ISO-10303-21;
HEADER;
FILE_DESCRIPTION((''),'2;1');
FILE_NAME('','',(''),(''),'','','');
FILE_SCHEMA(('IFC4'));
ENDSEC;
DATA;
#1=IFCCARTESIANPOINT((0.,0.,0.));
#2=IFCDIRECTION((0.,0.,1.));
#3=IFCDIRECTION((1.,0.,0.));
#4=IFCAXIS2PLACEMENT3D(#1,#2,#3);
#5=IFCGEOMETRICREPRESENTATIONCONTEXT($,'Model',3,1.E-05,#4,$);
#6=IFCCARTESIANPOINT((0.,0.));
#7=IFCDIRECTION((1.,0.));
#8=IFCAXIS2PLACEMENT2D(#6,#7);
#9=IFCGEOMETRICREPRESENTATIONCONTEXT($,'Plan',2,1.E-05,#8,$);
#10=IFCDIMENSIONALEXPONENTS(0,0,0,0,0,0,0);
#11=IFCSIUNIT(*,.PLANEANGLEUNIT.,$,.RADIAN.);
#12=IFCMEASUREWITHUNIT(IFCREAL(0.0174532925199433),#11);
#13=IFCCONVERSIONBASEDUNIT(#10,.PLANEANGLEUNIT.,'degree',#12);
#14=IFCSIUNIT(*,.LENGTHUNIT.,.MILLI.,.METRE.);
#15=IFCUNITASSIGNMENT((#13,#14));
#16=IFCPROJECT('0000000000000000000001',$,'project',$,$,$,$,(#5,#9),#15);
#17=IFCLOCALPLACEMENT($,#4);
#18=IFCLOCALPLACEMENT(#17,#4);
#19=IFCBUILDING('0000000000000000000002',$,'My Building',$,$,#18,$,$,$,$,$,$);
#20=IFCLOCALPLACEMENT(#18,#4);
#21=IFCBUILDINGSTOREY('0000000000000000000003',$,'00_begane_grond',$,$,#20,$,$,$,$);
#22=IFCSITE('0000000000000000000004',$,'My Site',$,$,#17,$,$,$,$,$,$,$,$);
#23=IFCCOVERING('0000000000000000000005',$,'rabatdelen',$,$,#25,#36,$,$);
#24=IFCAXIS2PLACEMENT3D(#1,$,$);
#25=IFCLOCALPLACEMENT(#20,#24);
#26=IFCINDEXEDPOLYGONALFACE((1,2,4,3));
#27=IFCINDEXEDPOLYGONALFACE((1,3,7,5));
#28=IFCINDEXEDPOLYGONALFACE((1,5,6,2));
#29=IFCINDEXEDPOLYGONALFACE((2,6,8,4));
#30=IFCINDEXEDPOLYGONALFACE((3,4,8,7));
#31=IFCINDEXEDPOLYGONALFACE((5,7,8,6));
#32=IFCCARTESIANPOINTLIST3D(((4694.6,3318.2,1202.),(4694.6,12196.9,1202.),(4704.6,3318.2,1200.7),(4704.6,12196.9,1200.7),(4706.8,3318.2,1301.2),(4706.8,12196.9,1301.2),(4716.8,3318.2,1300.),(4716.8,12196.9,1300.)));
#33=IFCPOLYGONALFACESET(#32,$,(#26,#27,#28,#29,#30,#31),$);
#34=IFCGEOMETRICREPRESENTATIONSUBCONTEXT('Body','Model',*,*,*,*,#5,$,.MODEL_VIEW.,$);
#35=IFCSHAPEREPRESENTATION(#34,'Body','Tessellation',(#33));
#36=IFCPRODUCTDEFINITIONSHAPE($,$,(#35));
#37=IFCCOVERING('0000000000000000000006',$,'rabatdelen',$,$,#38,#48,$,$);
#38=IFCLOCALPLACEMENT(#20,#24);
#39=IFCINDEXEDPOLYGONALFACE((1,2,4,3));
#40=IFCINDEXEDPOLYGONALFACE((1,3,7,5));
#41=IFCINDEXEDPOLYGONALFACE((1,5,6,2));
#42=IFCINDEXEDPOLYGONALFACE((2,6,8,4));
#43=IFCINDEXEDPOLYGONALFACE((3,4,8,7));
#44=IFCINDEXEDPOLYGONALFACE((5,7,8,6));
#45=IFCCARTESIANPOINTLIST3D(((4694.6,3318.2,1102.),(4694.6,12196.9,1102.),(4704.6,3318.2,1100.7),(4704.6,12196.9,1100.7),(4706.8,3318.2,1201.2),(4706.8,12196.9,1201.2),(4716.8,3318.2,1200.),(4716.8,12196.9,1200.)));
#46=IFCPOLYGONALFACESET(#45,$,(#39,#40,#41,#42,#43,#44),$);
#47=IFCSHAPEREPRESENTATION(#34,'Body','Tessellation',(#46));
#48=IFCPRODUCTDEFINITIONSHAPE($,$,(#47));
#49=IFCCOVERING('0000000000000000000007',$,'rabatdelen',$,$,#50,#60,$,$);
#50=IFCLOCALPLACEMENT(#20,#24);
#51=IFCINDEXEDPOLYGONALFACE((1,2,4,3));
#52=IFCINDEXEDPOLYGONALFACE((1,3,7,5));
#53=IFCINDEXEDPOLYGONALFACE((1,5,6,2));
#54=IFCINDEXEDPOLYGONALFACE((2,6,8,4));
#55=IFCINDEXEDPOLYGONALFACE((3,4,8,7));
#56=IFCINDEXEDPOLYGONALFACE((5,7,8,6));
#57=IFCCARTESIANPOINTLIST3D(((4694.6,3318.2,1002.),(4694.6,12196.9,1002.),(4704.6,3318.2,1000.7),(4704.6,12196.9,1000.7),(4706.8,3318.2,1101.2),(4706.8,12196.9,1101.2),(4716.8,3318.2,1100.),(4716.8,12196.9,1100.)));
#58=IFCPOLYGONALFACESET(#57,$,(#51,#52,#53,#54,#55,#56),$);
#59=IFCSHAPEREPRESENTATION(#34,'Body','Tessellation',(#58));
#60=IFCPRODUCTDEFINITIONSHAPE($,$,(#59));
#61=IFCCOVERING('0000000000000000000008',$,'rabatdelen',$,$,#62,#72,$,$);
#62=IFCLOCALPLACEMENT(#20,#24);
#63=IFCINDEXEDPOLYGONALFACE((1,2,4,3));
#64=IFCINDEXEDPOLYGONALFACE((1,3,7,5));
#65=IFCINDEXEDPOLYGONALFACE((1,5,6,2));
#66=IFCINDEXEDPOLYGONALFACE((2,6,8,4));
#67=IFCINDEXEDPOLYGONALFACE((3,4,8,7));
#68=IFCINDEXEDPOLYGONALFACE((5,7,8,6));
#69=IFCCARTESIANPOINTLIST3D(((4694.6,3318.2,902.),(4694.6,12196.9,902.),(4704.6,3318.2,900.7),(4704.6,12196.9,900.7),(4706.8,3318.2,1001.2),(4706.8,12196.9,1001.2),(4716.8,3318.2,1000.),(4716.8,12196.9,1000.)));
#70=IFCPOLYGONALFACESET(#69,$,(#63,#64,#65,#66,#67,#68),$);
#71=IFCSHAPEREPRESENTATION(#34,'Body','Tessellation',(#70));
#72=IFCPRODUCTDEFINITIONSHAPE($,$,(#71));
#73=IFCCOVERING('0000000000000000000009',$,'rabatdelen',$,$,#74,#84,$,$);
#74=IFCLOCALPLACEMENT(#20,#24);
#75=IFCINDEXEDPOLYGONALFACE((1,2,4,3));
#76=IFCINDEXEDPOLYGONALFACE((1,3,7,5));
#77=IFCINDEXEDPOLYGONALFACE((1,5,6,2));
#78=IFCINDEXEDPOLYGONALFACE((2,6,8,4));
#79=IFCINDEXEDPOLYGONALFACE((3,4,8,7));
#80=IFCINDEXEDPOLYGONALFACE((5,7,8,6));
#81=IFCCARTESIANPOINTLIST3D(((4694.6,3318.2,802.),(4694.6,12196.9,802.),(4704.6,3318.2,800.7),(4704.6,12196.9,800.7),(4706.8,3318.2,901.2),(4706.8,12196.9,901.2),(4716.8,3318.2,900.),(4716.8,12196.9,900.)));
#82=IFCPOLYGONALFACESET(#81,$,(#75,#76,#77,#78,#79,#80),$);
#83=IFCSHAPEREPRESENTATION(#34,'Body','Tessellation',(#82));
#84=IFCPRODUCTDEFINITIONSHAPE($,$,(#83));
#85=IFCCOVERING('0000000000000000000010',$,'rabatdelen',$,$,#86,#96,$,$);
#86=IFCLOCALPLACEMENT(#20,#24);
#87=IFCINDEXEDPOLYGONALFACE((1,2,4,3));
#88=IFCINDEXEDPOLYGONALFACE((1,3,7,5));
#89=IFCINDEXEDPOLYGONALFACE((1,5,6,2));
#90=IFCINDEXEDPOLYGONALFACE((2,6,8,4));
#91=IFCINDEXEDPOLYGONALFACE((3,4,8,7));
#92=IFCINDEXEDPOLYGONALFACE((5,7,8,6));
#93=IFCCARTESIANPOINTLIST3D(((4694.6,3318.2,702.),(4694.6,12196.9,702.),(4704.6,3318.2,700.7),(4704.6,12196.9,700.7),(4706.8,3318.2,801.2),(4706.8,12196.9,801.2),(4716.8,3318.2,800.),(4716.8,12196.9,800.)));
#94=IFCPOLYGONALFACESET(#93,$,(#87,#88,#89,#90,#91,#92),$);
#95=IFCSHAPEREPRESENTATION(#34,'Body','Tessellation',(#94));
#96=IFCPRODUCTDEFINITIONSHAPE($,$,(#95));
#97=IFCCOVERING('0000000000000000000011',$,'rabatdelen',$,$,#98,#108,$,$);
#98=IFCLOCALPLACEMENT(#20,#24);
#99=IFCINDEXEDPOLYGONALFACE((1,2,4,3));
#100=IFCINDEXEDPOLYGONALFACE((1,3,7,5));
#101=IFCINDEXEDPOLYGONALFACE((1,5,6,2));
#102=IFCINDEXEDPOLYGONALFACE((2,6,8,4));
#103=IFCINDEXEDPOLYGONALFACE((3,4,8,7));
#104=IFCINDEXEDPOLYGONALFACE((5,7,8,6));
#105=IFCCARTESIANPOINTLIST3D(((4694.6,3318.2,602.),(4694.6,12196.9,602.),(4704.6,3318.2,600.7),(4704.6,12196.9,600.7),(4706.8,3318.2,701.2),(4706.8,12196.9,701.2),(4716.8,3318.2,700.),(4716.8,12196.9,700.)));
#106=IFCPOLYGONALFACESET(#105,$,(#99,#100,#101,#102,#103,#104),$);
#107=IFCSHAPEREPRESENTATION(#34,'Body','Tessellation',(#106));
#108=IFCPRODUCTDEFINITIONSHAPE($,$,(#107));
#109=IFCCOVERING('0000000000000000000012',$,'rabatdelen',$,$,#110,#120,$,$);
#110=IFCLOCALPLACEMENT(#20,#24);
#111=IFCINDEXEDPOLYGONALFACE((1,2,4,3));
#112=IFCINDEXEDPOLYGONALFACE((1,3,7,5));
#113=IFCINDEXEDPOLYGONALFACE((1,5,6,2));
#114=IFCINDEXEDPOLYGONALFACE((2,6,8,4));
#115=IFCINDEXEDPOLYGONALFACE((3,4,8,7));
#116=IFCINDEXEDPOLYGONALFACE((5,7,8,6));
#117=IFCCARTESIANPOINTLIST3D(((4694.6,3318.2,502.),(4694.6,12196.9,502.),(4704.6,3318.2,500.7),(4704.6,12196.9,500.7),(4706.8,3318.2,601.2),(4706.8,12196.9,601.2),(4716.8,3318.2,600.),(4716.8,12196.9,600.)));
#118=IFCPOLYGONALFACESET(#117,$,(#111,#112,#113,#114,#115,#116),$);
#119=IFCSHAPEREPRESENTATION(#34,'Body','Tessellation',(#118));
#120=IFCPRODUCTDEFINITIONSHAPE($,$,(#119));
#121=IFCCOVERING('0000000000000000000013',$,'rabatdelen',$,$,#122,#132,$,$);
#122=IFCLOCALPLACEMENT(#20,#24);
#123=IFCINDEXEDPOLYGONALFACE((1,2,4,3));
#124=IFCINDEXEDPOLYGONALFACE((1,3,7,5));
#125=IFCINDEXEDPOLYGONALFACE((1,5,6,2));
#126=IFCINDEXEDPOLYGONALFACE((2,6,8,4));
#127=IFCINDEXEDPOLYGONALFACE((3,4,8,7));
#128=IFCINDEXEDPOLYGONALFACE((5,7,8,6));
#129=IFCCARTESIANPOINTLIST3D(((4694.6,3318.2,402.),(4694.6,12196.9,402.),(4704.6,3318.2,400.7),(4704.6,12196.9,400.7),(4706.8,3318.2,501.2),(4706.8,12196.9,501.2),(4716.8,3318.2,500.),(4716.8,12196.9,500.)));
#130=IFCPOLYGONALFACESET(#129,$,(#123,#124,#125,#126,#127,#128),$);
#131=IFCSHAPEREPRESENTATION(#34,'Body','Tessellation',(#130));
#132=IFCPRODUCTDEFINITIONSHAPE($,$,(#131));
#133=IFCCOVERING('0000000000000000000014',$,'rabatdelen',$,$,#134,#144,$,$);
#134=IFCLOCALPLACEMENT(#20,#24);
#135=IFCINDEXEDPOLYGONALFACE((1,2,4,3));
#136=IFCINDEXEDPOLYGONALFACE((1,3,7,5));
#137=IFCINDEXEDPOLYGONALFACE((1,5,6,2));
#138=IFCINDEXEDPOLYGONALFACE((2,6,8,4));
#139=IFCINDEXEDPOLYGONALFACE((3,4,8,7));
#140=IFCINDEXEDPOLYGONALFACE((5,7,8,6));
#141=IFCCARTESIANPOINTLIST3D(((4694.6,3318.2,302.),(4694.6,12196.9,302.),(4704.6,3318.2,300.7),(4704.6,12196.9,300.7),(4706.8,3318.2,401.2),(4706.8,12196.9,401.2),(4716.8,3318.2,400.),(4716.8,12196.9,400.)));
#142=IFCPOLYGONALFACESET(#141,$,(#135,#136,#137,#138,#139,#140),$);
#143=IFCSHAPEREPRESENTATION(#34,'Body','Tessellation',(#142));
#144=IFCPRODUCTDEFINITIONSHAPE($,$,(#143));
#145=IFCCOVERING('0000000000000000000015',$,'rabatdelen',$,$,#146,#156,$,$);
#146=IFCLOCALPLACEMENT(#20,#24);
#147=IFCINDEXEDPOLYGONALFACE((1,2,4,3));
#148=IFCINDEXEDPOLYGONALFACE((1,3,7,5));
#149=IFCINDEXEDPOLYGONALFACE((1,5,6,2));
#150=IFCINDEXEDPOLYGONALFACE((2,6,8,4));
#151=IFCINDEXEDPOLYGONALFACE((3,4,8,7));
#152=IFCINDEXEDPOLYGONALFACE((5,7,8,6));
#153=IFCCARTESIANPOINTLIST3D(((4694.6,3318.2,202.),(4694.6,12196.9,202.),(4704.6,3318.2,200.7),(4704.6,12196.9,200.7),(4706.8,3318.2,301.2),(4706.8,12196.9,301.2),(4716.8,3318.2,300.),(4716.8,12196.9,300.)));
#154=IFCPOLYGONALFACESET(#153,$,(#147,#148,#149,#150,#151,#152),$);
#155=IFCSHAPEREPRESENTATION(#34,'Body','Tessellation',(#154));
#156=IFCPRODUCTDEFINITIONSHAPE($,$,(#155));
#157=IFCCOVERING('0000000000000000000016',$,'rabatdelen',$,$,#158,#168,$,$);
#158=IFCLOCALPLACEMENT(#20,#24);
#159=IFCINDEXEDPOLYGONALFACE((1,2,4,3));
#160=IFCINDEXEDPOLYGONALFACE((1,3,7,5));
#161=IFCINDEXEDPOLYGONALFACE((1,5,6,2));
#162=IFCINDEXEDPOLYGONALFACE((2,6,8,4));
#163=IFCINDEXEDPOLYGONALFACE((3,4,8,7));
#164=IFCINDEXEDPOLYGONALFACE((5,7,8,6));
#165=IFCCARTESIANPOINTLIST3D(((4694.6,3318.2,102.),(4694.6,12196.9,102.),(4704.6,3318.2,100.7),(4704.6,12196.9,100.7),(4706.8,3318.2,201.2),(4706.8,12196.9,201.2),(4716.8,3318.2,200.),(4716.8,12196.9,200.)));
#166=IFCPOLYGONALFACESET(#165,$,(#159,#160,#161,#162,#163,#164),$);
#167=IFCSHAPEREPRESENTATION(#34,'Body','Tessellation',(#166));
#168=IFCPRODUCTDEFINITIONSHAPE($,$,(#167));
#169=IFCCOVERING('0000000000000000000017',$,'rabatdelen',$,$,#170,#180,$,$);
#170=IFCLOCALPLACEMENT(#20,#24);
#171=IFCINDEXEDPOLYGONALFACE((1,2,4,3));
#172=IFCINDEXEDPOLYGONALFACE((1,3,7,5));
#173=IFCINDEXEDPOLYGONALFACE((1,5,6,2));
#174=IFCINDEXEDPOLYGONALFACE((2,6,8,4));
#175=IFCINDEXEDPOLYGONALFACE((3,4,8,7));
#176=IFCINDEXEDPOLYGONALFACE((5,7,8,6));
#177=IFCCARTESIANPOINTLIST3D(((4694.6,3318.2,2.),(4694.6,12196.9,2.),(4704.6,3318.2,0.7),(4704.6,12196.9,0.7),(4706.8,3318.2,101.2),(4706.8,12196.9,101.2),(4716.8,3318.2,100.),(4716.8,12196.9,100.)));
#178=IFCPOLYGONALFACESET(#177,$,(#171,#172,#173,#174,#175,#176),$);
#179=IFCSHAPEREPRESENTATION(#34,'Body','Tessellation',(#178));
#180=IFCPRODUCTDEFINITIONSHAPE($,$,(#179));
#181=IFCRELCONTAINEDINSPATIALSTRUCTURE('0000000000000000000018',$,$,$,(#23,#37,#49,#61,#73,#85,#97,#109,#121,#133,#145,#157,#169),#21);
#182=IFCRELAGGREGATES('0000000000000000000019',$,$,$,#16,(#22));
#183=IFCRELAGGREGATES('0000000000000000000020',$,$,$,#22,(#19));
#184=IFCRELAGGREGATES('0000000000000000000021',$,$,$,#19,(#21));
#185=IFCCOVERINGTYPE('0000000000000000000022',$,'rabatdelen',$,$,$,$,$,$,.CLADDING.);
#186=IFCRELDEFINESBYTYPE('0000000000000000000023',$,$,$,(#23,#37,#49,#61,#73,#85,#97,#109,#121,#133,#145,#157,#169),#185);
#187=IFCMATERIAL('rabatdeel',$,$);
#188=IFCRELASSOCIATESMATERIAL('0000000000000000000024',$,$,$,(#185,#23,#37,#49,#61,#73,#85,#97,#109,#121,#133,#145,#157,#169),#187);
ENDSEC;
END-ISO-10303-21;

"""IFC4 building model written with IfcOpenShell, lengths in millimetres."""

from ifc_helpers import new_model, entity, si_unit, converted_unit, frame, origin_with_axes, origin_2d_with_axis, place, context, subcontext, project, spatial, rectangle, extrude, material, material_profile, profile_set, profile_usage, type_object, element, save


model = new_model("IFC4")

# Units and contexts
model_context = context("Model", 3, precision=1e-05, world=origin_with_axes())
plan_context = context("Plan", 2, precision=1e-05, world=origin_2d_with_axis())
body_context = subcontext(model_context, "Body", "Model", "MODEL_VIEW")
ifc_project = project(units=[converted_unit("PLANEANGLEUNIT", "degree", entity("IfcReal", 0.0174532925199433), si_unit("PLANEANGLEUNIT", "RADIAN"), dimensions=[0, 0, 0, 0, 0, 0, 0]), si_unit("LENGTHUNIT", "METRE", prefix="MILLI")], contexts=[model_context, plan_context])

# Site, building, storey
site_placement = place(None, origin_with_axes())
site = spatial("IfcSite", under=ifc_project, at=site_placement, Name="My Site")
building_placement = place(site_placement, origin_with_axes())
building = spatial("IfcBuilding", under=site, at=building_placement, Name="My Building")
storey_placement = place(building_placement, origin_with_axes())
storey = spatial("IfcBuildingStorey", under=building, at=storey_placement, Name="00_begane_grond")

# Coverings
ifc_material_1 = material(Name="rabatdeel")
ifc_material_profile_1 = material_profile(ifc_material_1, rectangle(XDim=10.0, YDim=100.0))
ifc_profile_set_1 = profile_set([ifc_material_profile_1])
covering_type = type_object("IfcCoveringType", Name="rabatdelen", PredefinedType="CLADDING", material=ifc_profile_set_1)
ifc_profile_usage_1 = profile_usage(ifc_profile_set_1, cardinal=7)
covering_1_placement = place(storey_placement, frame((4716.8, 12196.9, 1300.0), z_axis=(0.0, -1.0, 0.0), x_axis=(0.992546, 0.0, -0.121869)))
element("IfcCovering", 1, at=covering_1_placement, inside=storey, type_object=covering_type, material=ifc_profile_usage_1, Name="rabatdelen", context=body_context, shape_type="SweptSolid", body=[
    extrude(rectangle(XDim=10.0, YDim=100.0), frame((-5.0, -50.0, 0.0), z_axis=(0.0, 0.0, 1.0), x_axis=(1.0, 0.0, 0.0)), (0.0, 0.0, 1.0), 8878.8),
])
ifc_profile_usage_2 = profile_usage(ifc_profile_set_1, cardinal=7)
covering_2_placement = place(storey_placement, frame((4716.8, 12196.9, 1200.0), z_axis=(0.0, -1.0, 0.0), x_axis=(0.992546, 0.0, -0.121869)))
element("IfcCovering", 2, at=covering_2_placement, inside=storey, type_object=covering_type, material=ifc_profile_usage_2, Name="rabatdelen", context=body_context, shape_type="SweptSolid", body=[
    extrude(rectangle(XDim=10.0, YDim=100.0), frame((-5.0, -50.0, 0.0), z_axis=(0.0, 0.0, 1.0), x_axis=(1.0, 0.0, 0.0)), (0.0, 0.0, 1.0), 8878.8),
])
ifc_profile_usage_3 = profile_usage(ifc_profile_set_1, cardinal=7)
covering_3_placement = place(storey_placement, frame((4716.8, 12196.9, 1100.0), z_axis=(0.0, -1.0, 0.0), x_axis=(0.992546, 0.0, -0.121869)))
element("IfcCovering", 3, at=covering_3_placement, inside=storey, type_object=covering_type, material=ifc_profile_usage_3, Name="rabatdelen", context=body_context, shape_type="SweptSolid", body=[
    extrude(rectangle(XDim=10.0, YDim=100.0), frame((-5.0, -50.0, 0.0), z_axis=(0.0, 0.0, 1.0), x_axis=(1.0, 0.0, 0.0)), (0.0, 0.0, 1.0), 8878.8),
])
ifc_profile_usage_4 = profile_usage(ifc_profile_set_1, cardinal=7)
covering_4_placement = place(storey_placement, frame((4716.8, 12196.9, 1000.0), z_axis=(0.0, -1.0, 0.0), x_axis=(0.992546, 0.0, -0.121869)))
element("IfcCovering", 4, at=covering_4_placement, inside=storey, type_object=covering_type, material=ifc_profile_usage_4, Name="rabatdelen", context=body_context, shape_type="SweptSolid", body=[
    extrude(rectangle(XDim=10.0, YDim=100.0), frame((-5.0, -50.0, 0.0), z_axis=(0.0, 0.0, 1.0), x_axis=(1.0, 0.0, 0.0)), (0.0, 0.0, 1.0), 8878.8),
])
ifc_profile_usage_5 = profile_usage(ifc_profile_set_1, cardinal=7)
covering_5_placement = place(storey_placement, frame((4716.8, 12196.9, 900.0), z_axis=(0.0, -1.0, 0.0), x_axis=(0.992546, 0.0, -0.121869)))
element("IfcCovering", 5, at=covering_5_placement, inside=storey, type_object=covering_type, material=ifc_profile_usage_5, Name="rabatdelen", context=body_context, shape_type="SweptSolid", body=[
    extrude(rectangle(XDim=10.0, YDim=100.0), frame((-5.0, -50.0, 0.0), z_axis=(0.0, 0.0, 1.0), x_axis=(1.0, 0.0, 0.0)), (0.0, 0.0, 1.0), 8878.8),
])
ifc_profile_usage_6 = profile_usage(ifc_profile_set_1, cardinal=7)
covering_6_placement = place(storey_placement, frame((4716.8, 12196.9, 800.0), z_axis=(0.0, -1.0, 0.0), x_axis=(0.992546, 0.0, -0.121869)))
element("IfcCovering", 6, at=covering_6_placement, inside=storey, type_object=covering_type, material=ifc_profile_usage_6, Name="rabatdelen", context=body_context, shape_type="SweptSolid", body=[
    extrude(rectangle(XDim=10.0, YDim=100.0), frame((-5.0, -50.0, 0.0), z_axis=(0.0, 0.0, 1.0), x_axis=(1.0, 0.0, 0.0)), (0.0, 0.0, 1.0), 8878.8),
])
ifc_profile_usage_7 = profile_usage(ifc_profile_set_1, cardinal=7)
covering_7_placement = place(storey_placement, frame((4716.8, 12196.9, 700.0), z_axis=(0.0, -1.0, 0.0), x_axis=(0.992546, 0.0, -0.121869)))
element("IfcCovering", 7, at=covering_7_placement, inside=storey, type_object=covering_type, material=ifc_profile_usage_7, Name="rabatdelen", context=body_context, shape_type="SweptSolid", body=[
    extrude(rectangle(XDim=10.0, YDim=100.0), frame((-5.0, -50.0, 0.0), z_axis=(0.0, 0.0, 1.0), x_axis=(1.0, 0.0, 0.0)), (0.0, 0.0, 1.0), 8878.8),
])
ifc_profile_usage_8 = profile_usage(ifc_profile_set_1, cardinal=7)
covering_8_placement = place(storey_placement, frame((4716.8, 12196.9, 600.0), z_axis=(0.0, -1.0, 0.0), x_axis=(0.992546, 0.0, -0.121869)))
element("IfcCovering", 8, at=covering_8_placement, inside=storey, type_object=covering_type, material=ifc_profile_usage_8, Name="rabatdelen", context=body_context, shape_type="SweptSolid", body=[
    extrude(rectangle(XDim=10.0, YDim=100.0), frame((-5.0, -50.0, 0.0), z_axis=(0.0, 0.0, 1.0), x_axis=(1.0, 0.0, 0.0)), (0.0, 0.0, 1.0), 8878.8),
])
ifc_profile_usage_9 = profile_usage(ifc_profile_set_1, cardinal=7)
covering_9_placement = place(storey_placement, frame((4716.8, 12196.9, 500.0), z_axis=(0.0, -1.0, 0.0), x_axis=(0.992546, 0.0, -0.121869)))
element("IfcCovering", 9, at=covering_9_placement, inside=storey, type_object=covering_type, material=ifc_profile_usage_9, Name="rabatdelen", context=body_context, shape_type="SweptSolid", body=[
    extrude(rectangle(XDim=10.0, YDim=100.0), frame((-5.0, -50.0, 0.0), z_axis=(0.0, 0.0, 1.0), x_axis=(1.0, 0.0, 0.0)), (0.0, 0.0, 1.0), 8878.8),
])
ifc_profile_usage_10 = profile_usage(ifc_profile_set_1, cardinal=7)
covering_10_placement = place(storey_placement, frame((4716.8, 12196.9, 400.0), z_axis=(0.0, -1.0, 0.0), x_axis=(0.992546, 0.0, -0.121869)))
element("IfcCovering", 10, at=covering_10_placement, inside=storey, type_object=covering_type, material=ifc_profile_usage_10, Name="rabatdelen", context=body_context, shape_type="SweptSolid", body=[
    extrude(rectangle(XDim=10.0, YDim=100.0), frame((-5.0, -50.0, 0.0), z_axis=(0.0, 0.0, 1.0), x_axis=(1.0, 0.0, 0.0)), (0.0, 0.0, 1.0), 8878.8),
])
ifc_profile_usage_11 = profile_usage(ifc_profile_set_1, cardinal=7)
covering_11_placement = place(storey_placement, frame((4716.8, 12196.9, 300.0), z_axis=(0.0, -1.0, 0.0), x_axis=(0.992546, 0.0, -0.121869)))
element("IfcCovering", 11, at=covering_11_placement, inside=storey, type_object=covering_type, material=ifc_profile_usage_11, Name="rabatdelen", context=body_context, shape_type="SweptSolid", body=[
    extrude(rectangle(XDim=10.0, YDim=100.0), frame((-5.0, -50.0, 0.0), z_axis=(0.0, 0.0, 1.0), x_axis=(1.0, 0.0, 0.0)), (0.0, 0.0, 1.0), 8878.8),
])
ifc_profile_usage_12 = profile_usage(ifc_profile_set_1, cardinal=7)
covering_12_placement = place(storey_placement, frame((4716.8, 12196.9, 200.0), z_axis=(0.0, -1.0, 0.0), x_axis=(0.992546, 0.0, -0.121869)))
element("IfcCovering", 12, at=covering_12_placement, inside=storey, type_object=covering_type, material=ifc_profile_usage_12, Name="rabatdelen", context=body_context, shape_type="SweptSolid", body=[
    extrude(rectangle(XDim=10.0, YDim=100.0), frame((-5.0, -50.0, 0.0), z_axis=(0.0, 0.0, 1.0), x_axis=(1.0, 0.0, 0.0)), (0.0, 0.0, 1.0), 8878.8),
])
ifc_profile_usage_13 = profile_usage(ifc_profile_set_1, cardinal=7)
covering_13_placement = place(storey_placement, frame((4716.8, 12196.9, 100.0), z_axis=(0.0, -1.0, 0.0), x_axis=(0.992546, 0.0, -0.121869)))
element("IfcCovering", 13, at=covering_13_placement, inside=storey, type_object=covering_type, material=ifc_profile_usage_13, Name="rabatdelen", context=body_context, shape_type="SweptSolid", body=[
    extrude(rectangle(XDim=10.0, YDim=100.0), frame((-5.0, -50.0, 0.0), z_axis=(0.0, 0.0, 1.0), x_axis=(1.0, 0.0, 0.0)), (0.0, 0.0, 1.0), 8878.8),
])

save(model, "model.ifc")
